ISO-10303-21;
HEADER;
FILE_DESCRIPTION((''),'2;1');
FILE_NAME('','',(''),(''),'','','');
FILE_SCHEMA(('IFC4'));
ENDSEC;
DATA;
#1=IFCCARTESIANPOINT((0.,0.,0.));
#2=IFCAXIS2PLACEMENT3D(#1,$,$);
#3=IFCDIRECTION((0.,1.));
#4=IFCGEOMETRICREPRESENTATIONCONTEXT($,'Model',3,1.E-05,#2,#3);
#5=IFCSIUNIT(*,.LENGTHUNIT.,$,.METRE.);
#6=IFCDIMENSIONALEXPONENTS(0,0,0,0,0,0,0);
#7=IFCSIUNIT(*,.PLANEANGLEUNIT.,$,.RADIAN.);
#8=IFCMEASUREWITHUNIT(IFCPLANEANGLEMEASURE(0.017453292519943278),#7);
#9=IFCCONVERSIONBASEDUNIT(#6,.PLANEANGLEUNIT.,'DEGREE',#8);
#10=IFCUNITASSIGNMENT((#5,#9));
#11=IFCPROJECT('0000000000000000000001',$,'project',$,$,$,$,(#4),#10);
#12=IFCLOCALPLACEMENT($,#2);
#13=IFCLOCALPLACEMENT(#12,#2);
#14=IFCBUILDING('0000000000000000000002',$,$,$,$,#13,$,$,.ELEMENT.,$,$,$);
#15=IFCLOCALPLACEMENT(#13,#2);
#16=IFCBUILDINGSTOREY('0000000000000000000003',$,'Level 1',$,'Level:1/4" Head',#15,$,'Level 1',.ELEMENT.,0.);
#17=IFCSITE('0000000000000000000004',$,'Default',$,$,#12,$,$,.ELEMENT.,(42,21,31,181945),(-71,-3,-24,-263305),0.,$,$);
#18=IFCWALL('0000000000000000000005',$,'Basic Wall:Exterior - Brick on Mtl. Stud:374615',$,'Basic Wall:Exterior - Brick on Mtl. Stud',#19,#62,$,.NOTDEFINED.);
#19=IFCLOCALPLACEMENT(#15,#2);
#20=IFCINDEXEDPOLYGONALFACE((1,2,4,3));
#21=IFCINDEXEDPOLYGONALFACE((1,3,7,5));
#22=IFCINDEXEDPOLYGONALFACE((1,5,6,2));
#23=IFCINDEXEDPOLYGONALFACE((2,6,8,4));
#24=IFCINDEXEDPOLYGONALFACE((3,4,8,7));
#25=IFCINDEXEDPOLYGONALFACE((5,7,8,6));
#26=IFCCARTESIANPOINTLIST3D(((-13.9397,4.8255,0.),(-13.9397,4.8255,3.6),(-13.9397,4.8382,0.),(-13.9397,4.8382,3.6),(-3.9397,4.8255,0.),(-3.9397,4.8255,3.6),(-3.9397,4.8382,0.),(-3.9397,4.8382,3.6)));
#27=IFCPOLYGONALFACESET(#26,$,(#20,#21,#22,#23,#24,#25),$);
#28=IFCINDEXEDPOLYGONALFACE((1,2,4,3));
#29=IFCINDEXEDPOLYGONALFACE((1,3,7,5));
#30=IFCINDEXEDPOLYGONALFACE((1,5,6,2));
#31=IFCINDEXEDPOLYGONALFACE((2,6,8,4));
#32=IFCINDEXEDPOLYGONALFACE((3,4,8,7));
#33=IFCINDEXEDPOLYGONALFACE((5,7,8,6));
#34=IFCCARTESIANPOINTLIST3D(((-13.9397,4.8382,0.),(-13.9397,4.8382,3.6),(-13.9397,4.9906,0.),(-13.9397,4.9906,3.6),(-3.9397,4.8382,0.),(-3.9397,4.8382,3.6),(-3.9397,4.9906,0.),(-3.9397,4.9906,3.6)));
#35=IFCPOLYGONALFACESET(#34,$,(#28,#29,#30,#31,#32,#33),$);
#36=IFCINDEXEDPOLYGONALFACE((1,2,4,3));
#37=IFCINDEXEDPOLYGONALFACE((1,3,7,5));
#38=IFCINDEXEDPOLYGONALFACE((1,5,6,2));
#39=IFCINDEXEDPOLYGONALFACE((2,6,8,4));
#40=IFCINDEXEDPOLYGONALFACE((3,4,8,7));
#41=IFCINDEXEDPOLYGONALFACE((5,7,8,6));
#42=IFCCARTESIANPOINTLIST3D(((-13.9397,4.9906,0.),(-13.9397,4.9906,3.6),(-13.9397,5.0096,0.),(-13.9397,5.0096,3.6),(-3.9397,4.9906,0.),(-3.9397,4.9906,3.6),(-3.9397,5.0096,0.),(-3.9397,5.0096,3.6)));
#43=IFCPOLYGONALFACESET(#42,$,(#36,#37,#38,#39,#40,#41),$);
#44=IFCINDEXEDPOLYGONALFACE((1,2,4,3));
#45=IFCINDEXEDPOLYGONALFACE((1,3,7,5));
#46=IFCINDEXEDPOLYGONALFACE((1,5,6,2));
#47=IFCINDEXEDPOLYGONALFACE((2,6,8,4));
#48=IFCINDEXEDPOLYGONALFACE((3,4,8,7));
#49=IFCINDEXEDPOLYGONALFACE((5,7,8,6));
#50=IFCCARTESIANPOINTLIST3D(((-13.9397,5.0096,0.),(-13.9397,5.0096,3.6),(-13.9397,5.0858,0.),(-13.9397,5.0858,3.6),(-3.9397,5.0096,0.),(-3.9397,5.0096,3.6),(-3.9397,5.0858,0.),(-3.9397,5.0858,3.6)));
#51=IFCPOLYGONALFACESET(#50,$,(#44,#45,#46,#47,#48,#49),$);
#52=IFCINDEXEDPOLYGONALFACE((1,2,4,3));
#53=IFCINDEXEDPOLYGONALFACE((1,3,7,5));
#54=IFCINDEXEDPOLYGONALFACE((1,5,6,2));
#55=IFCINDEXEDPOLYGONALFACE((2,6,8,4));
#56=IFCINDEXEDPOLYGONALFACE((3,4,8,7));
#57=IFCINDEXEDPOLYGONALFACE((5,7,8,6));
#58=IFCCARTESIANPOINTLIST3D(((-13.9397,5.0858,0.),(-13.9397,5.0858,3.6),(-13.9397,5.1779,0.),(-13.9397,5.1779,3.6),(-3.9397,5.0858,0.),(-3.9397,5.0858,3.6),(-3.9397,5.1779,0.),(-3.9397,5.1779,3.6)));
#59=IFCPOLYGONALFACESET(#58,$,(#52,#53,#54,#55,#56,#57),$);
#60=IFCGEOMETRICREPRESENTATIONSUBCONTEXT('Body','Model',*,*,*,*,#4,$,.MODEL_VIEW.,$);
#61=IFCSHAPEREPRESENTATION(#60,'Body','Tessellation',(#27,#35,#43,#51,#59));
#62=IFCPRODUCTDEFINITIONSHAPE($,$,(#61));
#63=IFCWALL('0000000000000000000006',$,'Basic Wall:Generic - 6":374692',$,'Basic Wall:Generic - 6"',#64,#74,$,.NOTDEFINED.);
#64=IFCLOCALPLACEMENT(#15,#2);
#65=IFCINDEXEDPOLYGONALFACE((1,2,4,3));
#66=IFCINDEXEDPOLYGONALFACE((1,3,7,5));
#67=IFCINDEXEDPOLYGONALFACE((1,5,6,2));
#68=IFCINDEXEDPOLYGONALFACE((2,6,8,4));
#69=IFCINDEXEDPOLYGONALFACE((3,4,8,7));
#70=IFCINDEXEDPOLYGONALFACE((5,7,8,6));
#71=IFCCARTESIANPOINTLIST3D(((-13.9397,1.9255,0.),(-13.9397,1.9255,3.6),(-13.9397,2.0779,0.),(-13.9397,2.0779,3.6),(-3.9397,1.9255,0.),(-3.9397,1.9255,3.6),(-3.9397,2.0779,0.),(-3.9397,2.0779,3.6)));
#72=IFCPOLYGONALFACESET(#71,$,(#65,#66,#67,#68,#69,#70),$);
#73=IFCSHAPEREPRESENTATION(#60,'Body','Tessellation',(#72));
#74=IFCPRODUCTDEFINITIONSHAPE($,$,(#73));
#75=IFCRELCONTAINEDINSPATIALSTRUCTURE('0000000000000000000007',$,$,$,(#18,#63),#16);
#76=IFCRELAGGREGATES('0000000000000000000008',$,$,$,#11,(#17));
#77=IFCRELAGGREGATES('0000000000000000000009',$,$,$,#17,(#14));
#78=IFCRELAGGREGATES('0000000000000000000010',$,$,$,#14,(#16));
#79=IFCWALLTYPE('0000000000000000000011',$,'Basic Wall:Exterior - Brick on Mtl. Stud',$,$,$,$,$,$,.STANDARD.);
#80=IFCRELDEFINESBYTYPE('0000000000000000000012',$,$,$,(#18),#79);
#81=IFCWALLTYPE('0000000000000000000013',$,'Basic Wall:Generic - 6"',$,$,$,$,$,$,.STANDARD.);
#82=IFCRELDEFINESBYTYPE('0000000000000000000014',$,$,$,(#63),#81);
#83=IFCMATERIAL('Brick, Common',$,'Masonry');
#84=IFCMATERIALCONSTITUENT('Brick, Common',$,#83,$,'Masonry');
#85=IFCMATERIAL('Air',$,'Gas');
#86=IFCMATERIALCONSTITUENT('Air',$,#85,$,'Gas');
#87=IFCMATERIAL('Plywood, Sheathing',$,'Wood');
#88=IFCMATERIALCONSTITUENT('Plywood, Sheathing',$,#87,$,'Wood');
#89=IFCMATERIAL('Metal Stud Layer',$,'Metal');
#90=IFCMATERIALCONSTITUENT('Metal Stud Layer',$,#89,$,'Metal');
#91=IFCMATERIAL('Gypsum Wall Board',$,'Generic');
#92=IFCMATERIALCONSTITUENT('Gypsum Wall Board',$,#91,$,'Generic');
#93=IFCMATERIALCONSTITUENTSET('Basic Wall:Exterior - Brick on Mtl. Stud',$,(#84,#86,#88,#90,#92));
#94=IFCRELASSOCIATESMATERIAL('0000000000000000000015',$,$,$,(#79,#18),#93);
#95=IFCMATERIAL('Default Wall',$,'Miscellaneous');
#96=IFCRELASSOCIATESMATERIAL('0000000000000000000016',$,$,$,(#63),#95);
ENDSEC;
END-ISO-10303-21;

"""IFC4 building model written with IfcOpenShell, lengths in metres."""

from ifc_helpers import new_model, entity, si_unit, converted_unit, direction, frame, origin, place, context, subcontext, project, spatial, indexed_curve, outline, extrude, material, constituent, constituent_set, type_object, element, save


model = new_model("IFC4")

# Units and contexts
model_context = context("Model", 3, precision=1e-05, world=origin(), true_north=direction((0.0, 1.0)))
body_context = subcontext(model_context, "Body", "Model", "MODEL_VIEW")
ifc_project = project(units=[si_unit("LENGTHUNIT", "METRE"), converted_unit("PLANEANGLEUNIT", "DEGREE", entity("IfcPlaneAngleMeasure", 0.017453292519943278), si_unit("PLANEANGLEUNIT", "RADIAN"), dimensions=[0, 0, 0, 0, 0, 0, 0])], contexts=[model_context])

# Site, building, storey
site_placement = place(None, origin())
site = spatial("IfcSite", under=ifc_project, at=site_placement, Name="Default", CompositionType="ELEMENT", RefLatitude=(42, 21, 31, 181945), RefLongitude=(-71, -3, -24, -263305), RefElevation=0.0)
building_placement = place(site_placement, origin())
building = spatial("IfcBuilding", under=site, at=building_placement, CompositionType="ELEMENT")
storey_placement = place(building_placement, origin())
storey = spatial("IfcBuildingStorey", under=building, at=storey_placement, Name="Level 1", ObjectType="Level:1/4\" Head", LongName="Level 1", CompositionType="ELEMENT", Elevation=0.0)

# Walls
ifc_material_1 = material(Name="Brick, Common", Category="Masonry")
ifc_constituent_1 = constituent(ifc_material_1, Name="Brick, Common", Category="Masonry")
ifc_material_2 = material(Name="Air", Category="Gas")
ifc_constituent_2 = constituent(ifc_material_2, Name="Air", Category="Gas")
ifc_material_3 = material(Name="Plywood, Sheathing", Category="Wood")
ifc_constituent_3 = constituent(ifc_material_3, Name="Plywood, Sheathing", Category="Wood")
ifc_material_4 = material(Name="Metal Stud Layer", Category="Metal")
ifc_constituent_4 = constituent(ifc_material_4, Name="Metal Stud Layer", Category="Metal")
ifc_material_5 = material(Name="Gypsum Wall Board", Category="Generic")
ifc_constituent_5 = constituent(ifc_material_5, Name="Gypsum Wall Board", Category="Generic")
ifc_constituent_set = constituent_set(constituents=[ifc_constituent_1, ifc_constituent_2, ifc_constituent_3, ifc_constituent_4, ifc_constituent_5], Name="Basic Wall:Exterior - Brick on Mtl. Stud")
wall_type_1 = type_object("IfcWallType", Name="Basic Wall:Exterior - Brick on Mtl. Stud", PredefinedType="STANDARD", material=ifc_constituent_set)
wall_1_placement = place(storey_placement, frame((-13.9397, 5.0017, 0.0)))
element("IfcWall", 1, at=wall_1_placement, inside=storey, type_object=wall_type_1, material=ifc_constituent_set, Name="Basic Wall:Exterior - Brick on Mtl. Stud:374615", ObjectType="Basic Wall:Exterior - Brick on Mtl. Stud", PredefinedType="NOTDEFINED", context=body_context, shape_type="SweptSolid", body=[
    extrude(outline(indexed_curve([(-0.0064, -5.0), (0.0063, -5.0), (0.0064, 5.0), (-0.0063, 5.0), (-0.0064, -5.0)], self_intersect=False)), frame((5.0, -0.1699, 0.0), z_axis=(0.0, 0.0, 1.0), x_axis=(0.0, 1.0, 0.0)), (0.0, 0.0, 1.0), 3.6),
    extrude(outline(indexed_curve([(-5.0, -0.0762), (5.0, -0.0762), (5.0, 0.0762), (-5.0, 0.0762), (-5.0, -0.0762)], self_intersect=False)), frame((5.0, -0.0873, 0.0)), (0.0, 0.0, 1.0), 3.6),
    extrude(outline(indexed_curve([(-5.0, -0.0095), (5.0, -0.0095), (5.0, 0.0095), (-5.0, 0.0095), (-5.0, -0.0095)], self_intersect=False)), frame((5.0, -0.0016, 0.0)), (0.0, 0.0, 1.0), 3.6),
    extrude(outline(indexed_curve([(-5.0, -0.0381), (5.0, -0.0381), (5.0, 0.0381), (-5.0, 0.0381), (-5.0, -0.0381)], self_intersect=False)), frame((5.0, 0.046, 0.0)), (0.0, 0.0, 1.0), 3.6),
    extrude(outline(indexed_curve([(-0.046, -5.0), (0.046, -5.0), (0.046, 5.0), (-0.046, 5.0), (-0.046, -5.0)], self_intersect=False)), frame((5.0, 0.1302, 0.0), z_axis=(0.0, 0.0, 1.0), x_axis=(0.0, -1.0, 0.0)), (0.0, 0.0, 1.0), 3.6),
])
ifc_material_6 = material(Name="Default Wall", Category="Miscellaneous")
wall_type_2 = type_object("IfcWallType", Name="Basic Wall:Generic - 6\"", PredefinedType="STANDARD")
wall_2_placement = place(storey_placement, frame((-13.9397, 2.0017, 0.0)))
element("IfcWall", 2, at=wall_2_placement, inside=storey, type_object=wall_type_2, material=ifc_material_6, Name="Basic Wall:Generic - 6\":374692", ObjectType="Basic Wall:Generic - 6\"", PredefinedType="NOTDEFINED", context=body_context, shape_type="SweptSolid", body=[
    extrude(outline(indexed_curve([(10.0, 0.0762), (0.0, 0.0762), (0.0, -0.0762), (10.0, -0.0762), (10.0, 0.0762)], self_intersect=False)), origin(), (0.0, 0.0, 1.0), 3.6),
])

save(model, "model.ifc")
